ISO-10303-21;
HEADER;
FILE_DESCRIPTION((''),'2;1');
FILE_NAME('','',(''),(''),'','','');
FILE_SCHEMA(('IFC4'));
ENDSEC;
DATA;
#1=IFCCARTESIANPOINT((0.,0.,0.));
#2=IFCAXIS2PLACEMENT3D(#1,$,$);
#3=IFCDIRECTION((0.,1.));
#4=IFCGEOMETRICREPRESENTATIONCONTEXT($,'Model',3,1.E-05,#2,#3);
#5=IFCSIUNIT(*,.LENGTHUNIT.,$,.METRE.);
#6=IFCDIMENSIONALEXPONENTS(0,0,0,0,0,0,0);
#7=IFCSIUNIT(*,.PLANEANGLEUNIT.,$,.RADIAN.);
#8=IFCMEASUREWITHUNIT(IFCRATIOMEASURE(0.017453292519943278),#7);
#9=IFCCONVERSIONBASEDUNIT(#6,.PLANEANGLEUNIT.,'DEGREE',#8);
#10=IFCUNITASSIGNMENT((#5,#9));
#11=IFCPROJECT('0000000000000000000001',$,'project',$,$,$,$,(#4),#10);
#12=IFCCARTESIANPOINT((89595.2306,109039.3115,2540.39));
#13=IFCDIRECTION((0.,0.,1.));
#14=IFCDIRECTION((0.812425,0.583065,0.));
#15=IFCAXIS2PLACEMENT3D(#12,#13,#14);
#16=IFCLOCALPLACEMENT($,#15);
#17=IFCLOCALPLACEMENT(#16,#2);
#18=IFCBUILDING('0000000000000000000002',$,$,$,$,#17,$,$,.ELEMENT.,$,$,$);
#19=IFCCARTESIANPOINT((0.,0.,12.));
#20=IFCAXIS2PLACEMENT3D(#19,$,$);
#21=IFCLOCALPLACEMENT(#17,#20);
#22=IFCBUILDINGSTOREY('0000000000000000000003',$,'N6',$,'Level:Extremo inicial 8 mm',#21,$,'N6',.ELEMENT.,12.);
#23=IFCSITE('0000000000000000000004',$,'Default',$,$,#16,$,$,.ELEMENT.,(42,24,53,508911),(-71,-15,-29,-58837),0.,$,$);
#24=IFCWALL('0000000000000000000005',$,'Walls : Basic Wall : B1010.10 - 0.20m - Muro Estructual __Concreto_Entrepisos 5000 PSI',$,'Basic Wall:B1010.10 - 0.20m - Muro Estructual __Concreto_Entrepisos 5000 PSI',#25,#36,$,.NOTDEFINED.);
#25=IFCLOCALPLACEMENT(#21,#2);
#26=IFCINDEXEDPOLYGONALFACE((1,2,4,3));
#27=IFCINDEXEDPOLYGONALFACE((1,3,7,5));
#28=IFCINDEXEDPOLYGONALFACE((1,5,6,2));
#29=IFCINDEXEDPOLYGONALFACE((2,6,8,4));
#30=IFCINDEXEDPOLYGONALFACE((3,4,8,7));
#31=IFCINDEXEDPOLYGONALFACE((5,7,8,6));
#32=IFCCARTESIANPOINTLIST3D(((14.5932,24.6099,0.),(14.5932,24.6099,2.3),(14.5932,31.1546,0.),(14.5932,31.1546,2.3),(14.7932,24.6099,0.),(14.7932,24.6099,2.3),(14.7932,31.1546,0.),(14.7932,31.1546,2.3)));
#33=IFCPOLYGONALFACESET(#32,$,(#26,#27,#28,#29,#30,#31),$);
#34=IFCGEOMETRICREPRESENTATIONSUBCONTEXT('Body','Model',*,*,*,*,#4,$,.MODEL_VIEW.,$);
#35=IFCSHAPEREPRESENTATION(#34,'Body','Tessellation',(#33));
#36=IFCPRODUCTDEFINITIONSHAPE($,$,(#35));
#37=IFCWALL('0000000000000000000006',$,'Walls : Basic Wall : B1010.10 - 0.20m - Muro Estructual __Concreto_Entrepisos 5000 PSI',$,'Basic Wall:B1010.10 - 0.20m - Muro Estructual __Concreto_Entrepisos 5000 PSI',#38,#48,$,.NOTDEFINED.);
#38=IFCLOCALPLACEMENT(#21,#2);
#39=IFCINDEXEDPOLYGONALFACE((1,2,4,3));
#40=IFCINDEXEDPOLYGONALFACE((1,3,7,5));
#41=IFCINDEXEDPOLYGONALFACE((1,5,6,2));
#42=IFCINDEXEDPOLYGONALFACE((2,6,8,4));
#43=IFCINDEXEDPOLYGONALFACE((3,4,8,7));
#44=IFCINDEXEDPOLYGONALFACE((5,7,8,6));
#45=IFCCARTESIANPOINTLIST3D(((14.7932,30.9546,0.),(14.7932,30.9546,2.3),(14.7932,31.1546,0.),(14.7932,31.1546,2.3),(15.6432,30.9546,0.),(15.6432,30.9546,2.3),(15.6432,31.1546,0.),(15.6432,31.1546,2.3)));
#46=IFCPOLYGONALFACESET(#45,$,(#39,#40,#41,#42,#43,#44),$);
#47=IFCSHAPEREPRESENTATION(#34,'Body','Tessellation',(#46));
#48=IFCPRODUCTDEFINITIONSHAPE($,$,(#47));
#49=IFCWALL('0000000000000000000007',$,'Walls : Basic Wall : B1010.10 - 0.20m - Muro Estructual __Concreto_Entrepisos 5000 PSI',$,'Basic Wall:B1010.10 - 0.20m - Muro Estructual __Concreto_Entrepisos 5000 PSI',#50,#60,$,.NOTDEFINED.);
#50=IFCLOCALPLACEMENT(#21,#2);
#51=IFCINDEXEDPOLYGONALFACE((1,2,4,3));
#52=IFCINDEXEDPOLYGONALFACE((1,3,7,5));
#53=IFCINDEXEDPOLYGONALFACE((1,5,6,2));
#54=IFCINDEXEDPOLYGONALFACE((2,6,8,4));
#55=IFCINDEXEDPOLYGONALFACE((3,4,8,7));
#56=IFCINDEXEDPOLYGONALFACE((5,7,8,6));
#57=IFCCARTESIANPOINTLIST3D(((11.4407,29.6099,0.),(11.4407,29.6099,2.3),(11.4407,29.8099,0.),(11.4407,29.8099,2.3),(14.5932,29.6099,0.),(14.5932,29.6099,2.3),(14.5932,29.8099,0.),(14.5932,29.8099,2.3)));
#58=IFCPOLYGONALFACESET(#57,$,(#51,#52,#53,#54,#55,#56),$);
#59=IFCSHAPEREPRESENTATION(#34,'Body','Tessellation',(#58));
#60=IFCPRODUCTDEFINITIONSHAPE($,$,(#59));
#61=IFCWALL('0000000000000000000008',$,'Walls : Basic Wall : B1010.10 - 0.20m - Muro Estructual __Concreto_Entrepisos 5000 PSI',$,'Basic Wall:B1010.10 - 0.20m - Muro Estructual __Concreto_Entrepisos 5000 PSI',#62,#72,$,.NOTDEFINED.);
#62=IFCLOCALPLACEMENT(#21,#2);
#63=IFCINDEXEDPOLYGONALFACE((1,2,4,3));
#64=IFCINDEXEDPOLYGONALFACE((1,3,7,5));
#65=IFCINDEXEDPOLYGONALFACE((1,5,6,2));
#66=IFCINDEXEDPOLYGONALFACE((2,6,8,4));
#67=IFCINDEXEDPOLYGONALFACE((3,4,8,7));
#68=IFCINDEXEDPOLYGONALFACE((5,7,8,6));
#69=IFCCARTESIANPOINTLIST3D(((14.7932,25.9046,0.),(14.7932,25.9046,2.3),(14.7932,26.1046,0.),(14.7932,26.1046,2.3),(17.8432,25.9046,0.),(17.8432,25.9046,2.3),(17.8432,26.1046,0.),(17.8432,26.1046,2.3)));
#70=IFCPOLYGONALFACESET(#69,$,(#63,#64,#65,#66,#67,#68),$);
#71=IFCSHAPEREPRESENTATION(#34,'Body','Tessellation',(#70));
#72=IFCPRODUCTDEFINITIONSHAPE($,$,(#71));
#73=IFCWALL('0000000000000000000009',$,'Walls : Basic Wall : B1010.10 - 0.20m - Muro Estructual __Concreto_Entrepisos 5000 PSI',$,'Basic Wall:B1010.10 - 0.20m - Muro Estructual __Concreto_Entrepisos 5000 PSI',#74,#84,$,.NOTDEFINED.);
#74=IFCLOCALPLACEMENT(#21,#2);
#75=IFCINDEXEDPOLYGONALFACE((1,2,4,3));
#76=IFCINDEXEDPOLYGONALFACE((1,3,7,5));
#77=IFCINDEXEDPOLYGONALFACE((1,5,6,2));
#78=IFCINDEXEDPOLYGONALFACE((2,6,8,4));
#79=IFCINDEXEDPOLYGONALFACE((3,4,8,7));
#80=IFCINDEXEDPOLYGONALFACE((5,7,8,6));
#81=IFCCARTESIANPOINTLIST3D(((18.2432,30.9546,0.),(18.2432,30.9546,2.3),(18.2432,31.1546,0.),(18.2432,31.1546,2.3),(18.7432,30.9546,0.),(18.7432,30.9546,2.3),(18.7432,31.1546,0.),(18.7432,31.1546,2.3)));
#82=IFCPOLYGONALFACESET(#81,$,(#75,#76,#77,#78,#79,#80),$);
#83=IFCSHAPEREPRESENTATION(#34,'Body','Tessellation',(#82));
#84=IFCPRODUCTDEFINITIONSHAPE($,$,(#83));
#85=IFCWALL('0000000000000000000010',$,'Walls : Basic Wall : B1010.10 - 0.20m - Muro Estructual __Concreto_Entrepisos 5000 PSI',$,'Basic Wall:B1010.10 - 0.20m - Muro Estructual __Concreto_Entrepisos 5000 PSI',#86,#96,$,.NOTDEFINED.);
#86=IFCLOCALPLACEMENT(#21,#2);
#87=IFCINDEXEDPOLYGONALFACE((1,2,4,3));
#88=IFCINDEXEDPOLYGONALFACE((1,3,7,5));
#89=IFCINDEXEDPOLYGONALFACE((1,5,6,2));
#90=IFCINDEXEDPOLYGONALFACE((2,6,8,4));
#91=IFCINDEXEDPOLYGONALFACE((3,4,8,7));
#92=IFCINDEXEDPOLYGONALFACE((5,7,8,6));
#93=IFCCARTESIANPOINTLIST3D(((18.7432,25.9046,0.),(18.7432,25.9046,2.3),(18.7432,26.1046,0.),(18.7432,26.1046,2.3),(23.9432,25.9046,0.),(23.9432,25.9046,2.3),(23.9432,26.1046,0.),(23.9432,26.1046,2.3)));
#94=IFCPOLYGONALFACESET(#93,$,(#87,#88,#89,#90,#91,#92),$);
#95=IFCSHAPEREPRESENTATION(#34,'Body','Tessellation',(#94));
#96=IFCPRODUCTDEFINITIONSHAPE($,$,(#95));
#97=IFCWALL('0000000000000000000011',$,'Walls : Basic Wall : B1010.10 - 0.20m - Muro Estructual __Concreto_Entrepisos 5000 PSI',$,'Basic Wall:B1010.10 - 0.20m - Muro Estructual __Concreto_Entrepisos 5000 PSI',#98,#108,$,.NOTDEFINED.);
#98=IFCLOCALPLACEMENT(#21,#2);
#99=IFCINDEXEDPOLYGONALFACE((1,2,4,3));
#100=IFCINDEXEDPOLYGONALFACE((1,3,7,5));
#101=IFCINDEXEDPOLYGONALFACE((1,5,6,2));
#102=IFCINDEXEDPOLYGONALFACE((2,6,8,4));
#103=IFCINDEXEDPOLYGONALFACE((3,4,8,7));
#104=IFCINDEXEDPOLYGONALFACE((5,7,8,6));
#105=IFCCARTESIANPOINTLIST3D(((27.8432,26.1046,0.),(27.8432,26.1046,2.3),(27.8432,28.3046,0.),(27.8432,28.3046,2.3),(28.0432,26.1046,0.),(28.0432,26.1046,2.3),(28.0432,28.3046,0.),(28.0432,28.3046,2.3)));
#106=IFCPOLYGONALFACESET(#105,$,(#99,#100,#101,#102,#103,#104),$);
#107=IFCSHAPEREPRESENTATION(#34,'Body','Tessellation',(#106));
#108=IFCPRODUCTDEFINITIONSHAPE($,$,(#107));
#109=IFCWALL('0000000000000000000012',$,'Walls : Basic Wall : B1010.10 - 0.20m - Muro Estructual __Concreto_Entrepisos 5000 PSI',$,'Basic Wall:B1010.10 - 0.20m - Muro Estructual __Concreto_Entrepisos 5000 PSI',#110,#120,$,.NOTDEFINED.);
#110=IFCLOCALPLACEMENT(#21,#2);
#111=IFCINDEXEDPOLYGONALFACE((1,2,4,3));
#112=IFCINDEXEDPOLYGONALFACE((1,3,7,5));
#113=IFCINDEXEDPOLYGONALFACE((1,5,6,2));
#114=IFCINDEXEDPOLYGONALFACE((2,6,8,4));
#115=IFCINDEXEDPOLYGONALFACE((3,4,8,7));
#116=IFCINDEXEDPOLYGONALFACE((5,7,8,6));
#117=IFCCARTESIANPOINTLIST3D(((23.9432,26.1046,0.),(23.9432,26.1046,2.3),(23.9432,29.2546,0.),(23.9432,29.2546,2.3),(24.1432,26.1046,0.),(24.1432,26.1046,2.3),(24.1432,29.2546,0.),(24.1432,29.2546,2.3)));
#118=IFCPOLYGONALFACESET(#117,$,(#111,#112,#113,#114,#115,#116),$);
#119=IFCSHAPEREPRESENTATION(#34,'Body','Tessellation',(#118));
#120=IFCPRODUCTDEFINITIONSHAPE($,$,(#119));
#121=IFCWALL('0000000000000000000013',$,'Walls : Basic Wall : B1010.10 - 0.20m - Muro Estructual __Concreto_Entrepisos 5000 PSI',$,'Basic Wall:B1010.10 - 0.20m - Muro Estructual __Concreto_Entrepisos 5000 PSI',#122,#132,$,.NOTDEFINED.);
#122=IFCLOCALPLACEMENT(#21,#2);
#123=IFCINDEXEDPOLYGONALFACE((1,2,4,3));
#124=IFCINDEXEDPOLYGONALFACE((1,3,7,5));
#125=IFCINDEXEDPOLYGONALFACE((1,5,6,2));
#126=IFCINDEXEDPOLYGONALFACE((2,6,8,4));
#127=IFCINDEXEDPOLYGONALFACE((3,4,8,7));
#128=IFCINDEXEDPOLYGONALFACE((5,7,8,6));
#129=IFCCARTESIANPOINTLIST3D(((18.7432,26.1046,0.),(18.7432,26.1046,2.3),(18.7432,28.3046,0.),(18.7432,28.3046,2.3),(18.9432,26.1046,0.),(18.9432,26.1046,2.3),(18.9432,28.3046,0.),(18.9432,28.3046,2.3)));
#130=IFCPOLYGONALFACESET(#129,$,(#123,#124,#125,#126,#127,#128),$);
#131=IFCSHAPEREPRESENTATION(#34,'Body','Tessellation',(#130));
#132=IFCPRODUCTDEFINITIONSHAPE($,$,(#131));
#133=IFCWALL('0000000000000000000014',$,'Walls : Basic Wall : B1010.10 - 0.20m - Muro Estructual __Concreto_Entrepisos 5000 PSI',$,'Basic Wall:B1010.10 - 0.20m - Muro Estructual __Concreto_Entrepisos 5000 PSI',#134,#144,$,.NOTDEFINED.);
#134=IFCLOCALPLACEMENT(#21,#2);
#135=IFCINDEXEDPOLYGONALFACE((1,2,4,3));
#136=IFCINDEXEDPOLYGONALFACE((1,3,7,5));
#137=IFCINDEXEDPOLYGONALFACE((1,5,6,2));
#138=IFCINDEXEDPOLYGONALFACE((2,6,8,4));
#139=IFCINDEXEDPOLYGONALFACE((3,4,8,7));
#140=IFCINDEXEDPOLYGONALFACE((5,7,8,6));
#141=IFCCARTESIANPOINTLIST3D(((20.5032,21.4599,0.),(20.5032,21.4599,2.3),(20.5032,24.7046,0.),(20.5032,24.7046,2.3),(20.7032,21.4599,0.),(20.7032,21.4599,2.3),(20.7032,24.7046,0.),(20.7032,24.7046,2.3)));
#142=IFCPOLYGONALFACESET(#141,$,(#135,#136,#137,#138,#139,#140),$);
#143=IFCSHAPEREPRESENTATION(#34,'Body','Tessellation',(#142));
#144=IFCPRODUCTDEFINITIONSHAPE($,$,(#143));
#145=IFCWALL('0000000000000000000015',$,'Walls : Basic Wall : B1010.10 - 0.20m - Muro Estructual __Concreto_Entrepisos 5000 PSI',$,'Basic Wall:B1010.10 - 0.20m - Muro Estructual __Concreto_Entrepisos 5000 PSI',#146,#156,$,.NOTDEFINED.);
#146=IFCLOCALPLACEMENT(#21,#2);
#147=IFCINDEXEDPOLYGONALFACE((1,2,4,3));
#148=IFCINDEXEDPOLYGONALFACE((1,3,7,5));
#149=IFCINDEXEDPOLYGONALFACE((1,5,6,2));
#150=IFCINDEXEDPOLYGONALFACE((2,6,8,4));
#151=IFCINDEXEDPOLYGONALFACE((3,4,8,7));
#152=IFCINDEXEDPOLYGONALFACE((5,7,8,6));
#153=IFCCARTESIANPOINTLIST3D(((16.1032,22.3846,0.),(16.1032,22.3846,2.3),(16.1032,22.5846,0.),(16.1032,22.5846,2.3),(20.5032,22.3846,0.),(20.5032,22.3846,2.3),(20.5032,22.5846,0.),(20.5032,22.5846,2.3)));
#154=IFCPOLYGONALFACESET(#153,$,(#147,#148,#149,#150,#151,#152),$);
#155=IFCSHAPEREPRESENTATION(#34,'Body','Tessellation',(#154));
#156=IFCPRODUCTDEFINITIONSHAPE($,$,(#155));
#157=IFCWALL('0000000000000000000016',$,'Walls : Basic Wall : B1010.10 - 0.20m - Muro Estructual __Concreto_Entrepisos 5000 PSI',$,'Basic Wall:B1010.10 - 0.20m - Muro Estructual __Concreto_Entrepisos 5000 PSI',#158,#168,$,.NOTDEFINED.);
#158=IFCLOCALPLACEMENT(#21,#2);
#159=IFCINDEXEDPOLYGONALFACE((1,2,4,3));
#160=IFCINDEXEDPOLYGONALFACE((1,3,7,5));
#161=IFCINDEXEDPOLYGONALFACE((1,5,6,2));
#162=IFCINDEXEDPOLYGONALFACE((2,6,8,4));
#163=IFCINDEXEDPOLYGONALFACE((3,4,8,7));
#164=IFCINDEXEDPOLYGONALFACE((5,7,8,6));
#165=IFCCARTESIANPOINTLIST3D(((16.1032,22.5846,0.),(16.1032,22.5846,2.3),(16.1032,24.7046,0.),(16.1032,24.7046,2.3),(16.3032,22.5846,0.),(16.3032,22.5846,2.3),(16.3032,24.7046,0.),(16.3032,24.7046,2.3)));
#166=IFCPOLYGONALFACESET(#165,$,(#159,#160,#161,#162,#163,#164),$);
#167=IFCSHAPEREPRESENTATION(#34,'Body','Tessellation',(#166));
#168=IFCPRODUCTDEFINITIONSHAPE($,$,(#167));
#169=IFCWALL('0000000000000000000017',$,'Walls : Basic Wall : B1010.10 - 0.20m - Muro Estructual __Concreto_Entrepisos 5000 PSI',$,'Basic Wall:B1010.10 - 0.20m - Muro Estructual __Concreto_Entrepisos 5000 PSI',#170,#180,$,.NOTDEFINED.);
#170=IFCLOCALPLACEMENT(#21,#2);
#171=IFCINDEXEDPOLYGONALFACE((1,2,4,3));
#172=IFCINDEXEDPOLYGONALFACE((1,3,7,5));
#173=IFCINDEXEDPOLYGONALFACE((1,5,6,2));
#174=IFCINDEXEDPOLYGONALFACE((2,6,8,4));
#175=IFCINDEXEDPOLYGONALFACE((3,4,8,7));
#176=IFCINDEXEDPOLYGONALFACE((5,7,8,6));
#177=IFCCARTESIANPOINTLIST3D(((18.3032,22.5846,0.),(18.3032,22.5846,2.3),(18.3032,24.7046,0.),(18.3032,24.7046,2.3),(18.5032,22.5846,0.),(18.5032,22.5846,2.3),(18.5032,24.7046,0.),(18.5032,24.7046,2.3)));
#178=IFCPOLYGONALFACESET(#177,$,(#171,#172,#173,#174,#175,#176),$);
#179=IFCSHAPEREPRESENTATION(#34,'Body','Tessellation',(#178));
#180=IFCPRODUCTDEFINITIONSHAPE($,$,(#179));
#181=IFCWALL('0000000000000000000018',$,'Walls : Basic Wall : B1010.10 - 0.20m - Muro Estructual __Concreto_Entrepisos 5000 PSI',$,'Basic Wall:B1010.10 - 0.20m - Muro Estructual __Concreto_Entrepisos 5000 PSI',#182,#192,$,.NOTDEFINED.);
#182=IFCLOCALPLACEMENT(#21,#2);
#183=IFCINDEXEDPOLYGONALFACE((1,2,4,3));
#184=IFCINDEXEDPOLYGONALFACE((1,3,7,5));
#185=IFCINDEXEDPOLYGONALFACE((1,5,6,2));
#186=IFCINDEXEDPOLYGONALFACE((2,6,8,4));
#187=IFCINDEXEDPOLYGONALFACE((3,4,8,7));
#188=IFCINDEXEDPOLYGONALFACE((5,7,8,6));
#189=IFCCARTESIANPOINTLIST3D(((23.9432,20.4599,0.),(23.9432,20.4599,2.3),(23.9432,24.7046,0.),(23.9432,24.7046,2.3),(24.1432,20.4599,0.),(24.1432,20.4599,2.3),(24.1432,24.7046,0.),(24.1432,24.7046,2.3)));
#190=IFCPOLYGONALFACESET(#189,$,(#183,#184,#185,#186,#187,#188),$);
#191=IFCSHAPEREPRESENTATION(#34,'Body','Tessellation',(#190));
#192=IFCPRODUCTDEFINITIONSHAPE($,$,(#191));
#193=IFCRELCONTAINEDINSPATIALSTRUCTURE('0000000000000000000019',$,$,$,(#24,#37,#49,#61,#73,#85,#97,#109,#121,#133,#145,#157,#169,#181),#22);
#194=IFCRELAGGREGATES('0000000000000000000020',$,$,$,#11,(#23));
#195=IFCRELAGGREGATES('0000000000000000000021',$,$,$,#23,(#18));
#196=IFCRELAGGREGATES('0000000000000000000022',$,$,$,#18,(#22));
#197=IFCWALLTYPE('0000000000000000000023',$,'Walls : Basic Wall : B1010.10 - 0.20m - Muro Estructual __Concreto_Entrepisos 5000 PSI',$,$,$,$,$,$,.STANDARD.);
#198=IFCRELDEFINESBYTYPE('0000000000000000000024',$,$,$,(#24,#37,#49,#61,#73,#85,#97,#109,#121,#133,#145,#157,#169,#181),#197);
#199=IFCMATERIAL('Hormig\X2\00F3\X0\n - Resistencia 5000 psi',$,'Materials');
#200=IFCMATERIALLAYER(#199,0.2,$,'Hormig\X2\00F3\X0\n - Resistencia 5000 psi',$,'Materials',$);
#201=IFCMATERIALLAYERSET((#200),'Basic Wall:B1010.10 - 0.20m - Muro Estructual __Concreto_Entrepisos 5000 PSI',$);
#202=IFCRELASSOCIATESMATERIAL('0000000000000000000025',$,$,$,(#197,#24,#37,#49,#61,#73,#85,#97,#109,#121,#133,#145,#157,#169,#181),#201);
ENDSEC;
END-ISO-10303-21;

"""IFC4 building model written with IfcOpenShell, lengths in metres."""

from ifc_helpers import new_model, entity, si_unit, converted_unit, direction, frame, frame_2d, origin, place, context, subcontext, project, spatial, rectangle, extrude, material, layer, layer_set, layer_usage, type_object, element, save


model = new_model("IFC4")

# Units and contexts
model_context = context("Model", 3, precision=1e-05, world=origin(), true_north=direction((0.0, 1.0)))
body_context = subcontext(model_context, "Body", "Model", "MODEL_VIEW")
ifc_project = project(units=[si_unit("LENGTHUNIT", "METRE"), converted_unit("PLANEANGLEUNIT", "DEGREE", entity("IfcRatioMeasure", 0.017453292519943278), si_unit("PLANEANGLEUNIT", "RADIAN"), dimensions=[0, 0, 0, 0, 0, 0, 0])], contexts=[model_context])

# Site, building, storey
site_placement = place(None, frame((89595.2306, 109039.3115, 2540.39), z_axis=(0.0, 0.0, 1.0), x_axis=(0.812425, 0.583065, 0.0)))
site = spatial("IfcSite", under=ifc_project, at=site_placement, Name="Default", CompositionType="ELEMENT", RefLatitude=(42, 24, 53, 508911), RefLongitude=(-71, -15, -29, -58837), RefElevation=0.0)
building_placement = place(site_placement, origin())
building = spatial("IfcBuilding", under=site, at=building_placement, CompositionType="ELEMENT")
storey_placement = place(building_placement, frame((0.0, 0.0, 12.0)))
storey = spatial("IfcBuildingStorey", under=building, at=storey_placement, Name="N6", ObjectType="Level:Extremo inicial 8 mm", LongName="N6", CompositionType="ELEMENT", Elevation=12.0)

# Walls
ifc_material_1 = material(Name="Hormigón - Resistencia 5000 psi", Category="Materials")
ifc_layer_1 = layer(ifc_material_1, 0.2, Name="Hormigón - Resistencia 5000 psi", Category="Materials")
ifc_layer_set_1 = layer_set([ifc_layer_1], Name="Basic Wall:B1010.10 - 0.20m - Muro Estructual __Concreto_Entrepisos 5000 PSI")
ifc_layer_usage_1 = layer_usage(ifc_layer_set_1, "AXIS2", "NEGATIVE", 0.1)
wall_type_1 = type_object("IfcWallType", Name="Walls : Basic Wall : B1010.10 - 0.20m - Muro Estructual __Concreto_Entrepisos 5000 PSI", PredefinedType="STANDARD", material=ifc_layer_set_1)
wall_1_placement = place(storey_placement, frame((14.6932, 24.6099, 0.0), z_axis=(0.0, 0.0, 1.0), x_axis=(0.0, 1.0, 0.0)))
element("IfcWall", 1, at=wall_1_placement, inside=storey, type_object=wall_type_1, material=ifc_layer_usage_1, Name="Walls : Basic Wall : B1010.10 - 0.20m - Muro Estructual __Concreto_Entrepisos 5000 PSI", ObjectType="Basic Wall:B1010.10 - 0.20m - Muro Estructual __Concreto_Entrepisos 5000 PSI", PredefinedType="NOTDEFINED", context=body_context, shape_type="SweptSolid", body=[
    extrude(rectangle(XDim=6.5447, YDim=0.2, at=frame_2d((3.2724, 0.0), x_axis=(-1.0, 0.0))), origin(), (0.0, 0.0, 1.0), 2.3),
])
ifc_layer_usage_2 = layer_usage(ifc_layer_set_1, "AXIS2", "NEGATIVE", 0.1)
wall_2_placement = place(storey_placement, frame((15.6432, 31.0546, 0.0), z_axis=(0.0, 0.0, 1.0), x_axis=(-1.0, 0.0, 0.0)))
element("IfcWall", 2, at=wall_2_placement, inside=storey, type_object=wall_type_1, material=ifc_layer_usage_2, Name="Walls : Basic Wall : B1010.10 - 0.20m - Muro Estructual __Concreto_Entrepisos 5000 PSI", ObjectType="Basic Wall:B1010.10 - 0.20m - Muro Estructual __Concreto_Entrepisos 5000 PSI", PredefinedType="NOTDEFINED", context=body_context, shape_type="SweptSolid", body=[
    extrude(rectangle(XDim=0.85, YDim=0.2, at=frame_2d((0.425, 0.0), x_axis=(-1.0, 0.0))), origin(), (0.0, 0.0, 1.0), 2.3),
])
ifc_layer_usage_3 = layer_usage(ifc_layer_set_1, "AXIS2", "NEGATIVE", 0.1)
wall_3_placement = place(storey_placement, frame((11.4407, 29.7099, 0.0)))
element("IfcWall", 3, at=wall_3_placement, inside=storey, type_object=wall_type_1, material=ifc_layer_usage_3, Name="Walls : Basic Wall : B1010.10 - 0.20m - Muro Estructual __Concreto_Entrepisos 5000 PSI", ObjectType="Basic Wall:B1010.10 - 0.20m - Muro Estructual __Concreto_Entrepisos 5000 PSI", PredefinedType="NOTDEFINED", context=body_context, shape_type="SweptSolid", body=[
    extrude(rectangle(XDim=3.1525, YDim=0.2, at=frame_2d((1.5763, 0.0), x_axis=(-1.0, 0.0))), origin(), (0.0, 0.0, 1.0), 2.3),
])
ifc_layer_usage_4 = layer_usage(ifc_layer_set_1, "AXIS2", "NEGATIVE", 0.1)
wall_4_placement = place(storey_placement, frame((17.8432, 26.0046, 0.0), z_axis=(0.0, 0.0, 1.0), x_axis=(-1.0, 0.0, 0.0)))
element("IfcWall", 4, at=wall_4_placement, inside=storey, type_object=wall_type_1, material=ifc_layer_usage_4, Name="Walls : Basic Wall : B1010.10 - 0.20m - Muro Estructual __Concreto_Entrepisos 5000 PSI", ObjectType="Basic Wall:B1010.10 - 0.20m - Muro Estructual __Concreto_Entrepisos 5000 PSI", PredefinedType="NOTDEFINED", context=body_context, shape_type="SweptSolid", body=[
    extrude(rectangle(XDim=3.05, YDim=0.2, at=frame_2d((1.525, 0.0), x_axis=(-1.0, 0.0))), origin(), (0.0, 0.0, 1.0), 2.3),
])
ifc_layer_usage_5 = layer_usage(ifc_layer_set_1, "AXIS2", "NEGATIVE", 0.1)
wall_5_placement = place(storey_placement, frame((18.7432, 31.0546, 0.0), z_axis=(0.0, 0.0, 1.0), x_axis=(-1.0, 0.0, 0.0)))
element("IfcWall", 5, at=wall_5_placement, inside=storey, type_object=wall_type_1, material=ifc_layer_usage_5, Name="Walls : Basic Wall : B1010.10 - 0.20m - Muro Estructual __Concreto_Entrepisos 5000 PSI", ObjectType="Basic Wall:B1010.10 - 0.20m - Muro Estructual __Concreto_Entrepisos 5000 PSI", PredefinedType="NOTDEFINED", context=body_context, shape_type="SweptSolid", body=[
    extrude(rectangle(XDim=0.5, YDim=0.2, at=frame_2d((0.25, 0.0), x_axis=(-1.0, 0.0))), origin(), (0.0, 0.0, 1.0), 2.3),
])
ifc_layer_usage_6 = layer_usage(ifc_layer_set_1, "AXIS2", "NEGATIVE", 0.1)
wall_6_placement = place(storey_placement, frame((18.7432, 26.0046, 0.0)))
element("IfcWall", 6, at=wall_6_placement, inside=storey, type_object=wall_type_1, material=ifc_layer_usage_6, Name="Walls : Basic Wall : B1010.10 - 0.20m - Muro Estructual __Concreto_Entrepisos 5000 PSI", ObjectType="Basic Wall:B1010.10 - 0.20m - Muro Estructual __Concreto_Entrepisos 5000 PSI", PredefinedType="NOTDEFINED", context=body_context, shape_type="SweptSolid", body=[
    extrude(rectangle(XDim=5.2, YDim=0.2, at=frame_2d((2.6, 0.0), x_axis=(-1.0, 0.0))), origin(), (0.0, 0.0, 1.0), 2.3),
])
ifc_layer_usage_7 = layer_usage(ifc_layer_set_1, "AXIS2", "NEGATIVE", 0.1)
wall_7_placement = place(storey_placement, frame((27.9432, 28.3046, 0.0), z_axis=(0.0, 0.0, 1.0), x_axis=(0.0, -1.0, 0.0)))
element("IfcWall", 7, at=wall_7_placement, inside=storey, type_object=wall_type_1, material=ifc_layer_usage_7, Name="Walls : Basic Wall : B1010.10 - 0.20m - Muro Estructual __Concreto_Entrepisos 5000 PSI", ObjectType="Basic Wall:B1010.10 - 0.20m - Muro Estructual __Concreto_Entrepisos 5000 PSI", PredefinedType="NOTDEFINED", context=body_context, shape_type="SweptSolid", body=[
    extrude(rectangle(XDim=2.2, YDim=0.2, at=frame_2d((1.1, 0.0), x_axis=(-1.0, 0.0))), origin(), (0.0, 0.0, 1.0), 2.3),
])
ifc_layer_usage_8 = layer_usage(ifc_layer_set_1, "AXIS2", "NEGATIVE", 0.1)
wall_8_placement = place(storey_placement, frame((24.0432, 26.1046, 0.0), z_axis=(0.0, 0.0, 1.0), x_axis=(0.0, 1.0, 0.0)))
element("IfcWall", 8, at=wall_8_placement, inside=storey, type_object=wall_type_1, material=ifc_layer_usage_8, Name="Walls : Basic Wall : B1010.10 - 0.20m - Muro Estructual __Concreto_Entrepisos 5000 PSI", ObjectType="Basic Wall:B1010.10 - 0.20m - Muro Estructual __Concreto_Entrepisos 5000 PSI", PredefinedType="NOTDEFINED", context=body_context, shape_type="SweptSolid", body=[
    extrude(rectangle(XDim=3.15, YDim=0.2, at=frame_2d((1.575, 0.0), x_axis=(-1.0, 0.0))), origin(), (0.0, 0.0, 1.0), 2.3),
])
ifc_layer_usage_9 = layer_usage(ifc_layer_set_1, "AXIS2", "NEGATIVE", 0.1)
wall_9_placement = place(storey_placement, frame((18.8432, 28.3046, 0.0), z_axis=(0.0, 0.0, 1.0), x_axis=(0.0, -1.0, 0.0)))
element("IfcWall", 9, at=wall_9_placement, inside=storey, type_object=wall_type_1, material=ifc_layer_usage_9, Name="Walls : Basic Wall : B1010.10 - 0.20m - Muro Estructual __Concreto_Entrepisos 5000 PSI", ObjectType="Basic Wall:B1010.10 - 0.20m - Muro Estructual __Concreto_Entrepisos 5000 PSI", PredefinedType="NOTDEFINED", context=body_context, shape_type="SweptSolid", body=[
    extrude(rectangle(XDim=2.2, YDim=0.2, at=frame_2d((1.1, 0.0), x_axis=(-1.0, 0.0))), origin(), (0.0, 0.0, 1.0), 2.3),
])
ifc_layer_usage_10 = layer_usage(ifc_layer_set_1, "AXIS2", "NEGATIVE", 0.1)
wall_10_placement = place(storey_placement, frame((20.6032, 21.4599, 0.0), z_axis=(0.0, 0.0, 1.0), x_axis=(0.0, 1.0, 0.0)))
element("IfcWall", 10, at=wall_10_placement, inside=storey, type_object=wall_type_1, material=ifc_layer_usage_10, Name="Walls : Basic Wall : B1010.10 - 0.20m - Muro Estructual __Concreto_Entrepisos 5000 PSI", ObjectType="Basic Wall:B1010.10 - 0.20m - Muro Estructual __Concreto_Entrepisos 5000 PSI", PredefinedType="NOTDEFINED", context=body_context, shape_type="SweptSolid", body=[
    extrude(rectangle(XDim=3.2447, YDim=0.2, at=frame_2d((1.6224, 0.0), x_axis=(-1.0, 0.0))), origin(), (0.0, 0.0, 1.0), 2.3),
])
ifc_layer_usage_11 = layer_usage(ifc_layer_set_1, "AXIS2", "NEGATIVE", 0.1)
wall_11_placement = place(storey_placement, frame((20.5032, 22.4846, 0.0), z_axis=(0.0, 0.0, 1.0), x_axis=(-1.0, 0.0, 0.0)))
element("IfcWall", 11, at=wall_11_placement, inside=storey, type_object=wall_type_1, material=ifc_layer_usage_11, Name="Walls : Basic Wall : B1010.10 - 0.20m - Muro Estructual __Concreto_Entrepisos 5000 PSI", ObjectType="Basic Wall:B1010.10 - 0.20m - Muro Estructual __Concreto_Entrepisos 5000 PSI", PredefinedType="NOTDEFINED", context=body_context, shape_type="SweptSolid", body=[
    extrude(rectangle(XDim=4.4, YDim=0.2, at=frame_2d((2.2, 0.0), x_axis=(-1.0, 0.0))), origin(), (0.0, 0.0, 1.0), 2.3),
])
ifc_layer_usage_12 = layer_usage(ifc_layer_set_1, "AXIS2", "NEGATIVE", 0.1)
wall_12_placement = place(storey_placement, frame((16.2032, 22.5846, 0.0), z_axis=(0.0, 0.0, 1.0), x_axis=(0.0, 1.0, 0.0)))
element("IfcWall", 12, at=wall_12_placement, inside=storey, type_object=wall_type_1, material=ifc_layer_usage_12, Name="Walls : Basic Wall : B1010.10 - 0.20m - Muro Estructual __Concreto_Entrepisos 5000 PSI", ObjectType="Basic Wall:B1010.10 - 0.20m - Muro Estructual __Concreto_Entrepisos 5000 PSI", PredefinedType="NOTDEFINED", context=body_context, shape_type="SweptSolid", body=[
    extrude(rectangle(XDim=2.12, YDim=0.2, at=frame_2d((1.06, 0.0), x_axis=(-1.0, 0.0))), origin(), (0.0, 0.0, 1.0), 2.3),
])
ifc_layer_usage_13 = layer_usage(ifc_layer_set_1, "AXIS2", "NEGATIVE", 0.1)
wall_13_placement = place(storey_placement, frame((18.4032, 24.7046, 0.0), z_axis=(0.0, 0.0, 1.0), x_axis=(0.0, -1.0, 0.0)))
element("IfcWall", 13, at=wall_13_placement, inside=storey, type_object=wall_type_1, material=ifc_layer_usage_13, Name="Walls : Basic Wall : B1010.10 - 0.20m - Muro Estructual __Concreto_Entrepisos 5000 PSI", ObjectType="Basic Wall:B1010.10 - 0.20m - Muro Estructual __Concreto_Entrepisos 5000 PSI", PredefinedType="NOTDEFINED", context=body_context, shape_type="SweptSolid", body=[
    extrude(rectangle(XDim=2.12, YDim=0.2, at=frame_2d((1.06, 0.0), x_axis=(-1.0, 0.0))), origin(), (0.0, 0.0, 1.0), 2.3),
])
ifc_layer_usage_14 = layer_usage(ifc_layer_set_1, "AXIS2", "NEGATIVE", 0.1)
wall_14_placement = place(storey_placement, frame((24.0432, 20.4599, 0.0), z_axis=(0.0, 0.0, 1.0), x_axis=(0.0, 1.0, 0.0)))
element("IfcWall", 14, at=wall_14_placement, inside=storey, type_object=wall_type_1, material=ifc_layer_usage_14, Name="Walls : Basic Wall : B1010.10 - 0.20m - Muro Estructual __Concreto_Entrepisos 5000 PSI", ObjectType="Basic Wall:B1010.10 - 0.20m - Muro Estructual __Concreto_Entrepisos 5000 PSI", PredefinedType="NOTDEFINED", context=body_context, shape_type="SweptSolid", body=[
    extrude(rectangle(XDim=4.2447, YDim=0.2, at=frame_2d((2.1224, 0.0), x_axis=(-1.0, 0.0))), origin(), (0.0, 0.0, 1.0), 2.3),
])

save(model, "model.ifc")
